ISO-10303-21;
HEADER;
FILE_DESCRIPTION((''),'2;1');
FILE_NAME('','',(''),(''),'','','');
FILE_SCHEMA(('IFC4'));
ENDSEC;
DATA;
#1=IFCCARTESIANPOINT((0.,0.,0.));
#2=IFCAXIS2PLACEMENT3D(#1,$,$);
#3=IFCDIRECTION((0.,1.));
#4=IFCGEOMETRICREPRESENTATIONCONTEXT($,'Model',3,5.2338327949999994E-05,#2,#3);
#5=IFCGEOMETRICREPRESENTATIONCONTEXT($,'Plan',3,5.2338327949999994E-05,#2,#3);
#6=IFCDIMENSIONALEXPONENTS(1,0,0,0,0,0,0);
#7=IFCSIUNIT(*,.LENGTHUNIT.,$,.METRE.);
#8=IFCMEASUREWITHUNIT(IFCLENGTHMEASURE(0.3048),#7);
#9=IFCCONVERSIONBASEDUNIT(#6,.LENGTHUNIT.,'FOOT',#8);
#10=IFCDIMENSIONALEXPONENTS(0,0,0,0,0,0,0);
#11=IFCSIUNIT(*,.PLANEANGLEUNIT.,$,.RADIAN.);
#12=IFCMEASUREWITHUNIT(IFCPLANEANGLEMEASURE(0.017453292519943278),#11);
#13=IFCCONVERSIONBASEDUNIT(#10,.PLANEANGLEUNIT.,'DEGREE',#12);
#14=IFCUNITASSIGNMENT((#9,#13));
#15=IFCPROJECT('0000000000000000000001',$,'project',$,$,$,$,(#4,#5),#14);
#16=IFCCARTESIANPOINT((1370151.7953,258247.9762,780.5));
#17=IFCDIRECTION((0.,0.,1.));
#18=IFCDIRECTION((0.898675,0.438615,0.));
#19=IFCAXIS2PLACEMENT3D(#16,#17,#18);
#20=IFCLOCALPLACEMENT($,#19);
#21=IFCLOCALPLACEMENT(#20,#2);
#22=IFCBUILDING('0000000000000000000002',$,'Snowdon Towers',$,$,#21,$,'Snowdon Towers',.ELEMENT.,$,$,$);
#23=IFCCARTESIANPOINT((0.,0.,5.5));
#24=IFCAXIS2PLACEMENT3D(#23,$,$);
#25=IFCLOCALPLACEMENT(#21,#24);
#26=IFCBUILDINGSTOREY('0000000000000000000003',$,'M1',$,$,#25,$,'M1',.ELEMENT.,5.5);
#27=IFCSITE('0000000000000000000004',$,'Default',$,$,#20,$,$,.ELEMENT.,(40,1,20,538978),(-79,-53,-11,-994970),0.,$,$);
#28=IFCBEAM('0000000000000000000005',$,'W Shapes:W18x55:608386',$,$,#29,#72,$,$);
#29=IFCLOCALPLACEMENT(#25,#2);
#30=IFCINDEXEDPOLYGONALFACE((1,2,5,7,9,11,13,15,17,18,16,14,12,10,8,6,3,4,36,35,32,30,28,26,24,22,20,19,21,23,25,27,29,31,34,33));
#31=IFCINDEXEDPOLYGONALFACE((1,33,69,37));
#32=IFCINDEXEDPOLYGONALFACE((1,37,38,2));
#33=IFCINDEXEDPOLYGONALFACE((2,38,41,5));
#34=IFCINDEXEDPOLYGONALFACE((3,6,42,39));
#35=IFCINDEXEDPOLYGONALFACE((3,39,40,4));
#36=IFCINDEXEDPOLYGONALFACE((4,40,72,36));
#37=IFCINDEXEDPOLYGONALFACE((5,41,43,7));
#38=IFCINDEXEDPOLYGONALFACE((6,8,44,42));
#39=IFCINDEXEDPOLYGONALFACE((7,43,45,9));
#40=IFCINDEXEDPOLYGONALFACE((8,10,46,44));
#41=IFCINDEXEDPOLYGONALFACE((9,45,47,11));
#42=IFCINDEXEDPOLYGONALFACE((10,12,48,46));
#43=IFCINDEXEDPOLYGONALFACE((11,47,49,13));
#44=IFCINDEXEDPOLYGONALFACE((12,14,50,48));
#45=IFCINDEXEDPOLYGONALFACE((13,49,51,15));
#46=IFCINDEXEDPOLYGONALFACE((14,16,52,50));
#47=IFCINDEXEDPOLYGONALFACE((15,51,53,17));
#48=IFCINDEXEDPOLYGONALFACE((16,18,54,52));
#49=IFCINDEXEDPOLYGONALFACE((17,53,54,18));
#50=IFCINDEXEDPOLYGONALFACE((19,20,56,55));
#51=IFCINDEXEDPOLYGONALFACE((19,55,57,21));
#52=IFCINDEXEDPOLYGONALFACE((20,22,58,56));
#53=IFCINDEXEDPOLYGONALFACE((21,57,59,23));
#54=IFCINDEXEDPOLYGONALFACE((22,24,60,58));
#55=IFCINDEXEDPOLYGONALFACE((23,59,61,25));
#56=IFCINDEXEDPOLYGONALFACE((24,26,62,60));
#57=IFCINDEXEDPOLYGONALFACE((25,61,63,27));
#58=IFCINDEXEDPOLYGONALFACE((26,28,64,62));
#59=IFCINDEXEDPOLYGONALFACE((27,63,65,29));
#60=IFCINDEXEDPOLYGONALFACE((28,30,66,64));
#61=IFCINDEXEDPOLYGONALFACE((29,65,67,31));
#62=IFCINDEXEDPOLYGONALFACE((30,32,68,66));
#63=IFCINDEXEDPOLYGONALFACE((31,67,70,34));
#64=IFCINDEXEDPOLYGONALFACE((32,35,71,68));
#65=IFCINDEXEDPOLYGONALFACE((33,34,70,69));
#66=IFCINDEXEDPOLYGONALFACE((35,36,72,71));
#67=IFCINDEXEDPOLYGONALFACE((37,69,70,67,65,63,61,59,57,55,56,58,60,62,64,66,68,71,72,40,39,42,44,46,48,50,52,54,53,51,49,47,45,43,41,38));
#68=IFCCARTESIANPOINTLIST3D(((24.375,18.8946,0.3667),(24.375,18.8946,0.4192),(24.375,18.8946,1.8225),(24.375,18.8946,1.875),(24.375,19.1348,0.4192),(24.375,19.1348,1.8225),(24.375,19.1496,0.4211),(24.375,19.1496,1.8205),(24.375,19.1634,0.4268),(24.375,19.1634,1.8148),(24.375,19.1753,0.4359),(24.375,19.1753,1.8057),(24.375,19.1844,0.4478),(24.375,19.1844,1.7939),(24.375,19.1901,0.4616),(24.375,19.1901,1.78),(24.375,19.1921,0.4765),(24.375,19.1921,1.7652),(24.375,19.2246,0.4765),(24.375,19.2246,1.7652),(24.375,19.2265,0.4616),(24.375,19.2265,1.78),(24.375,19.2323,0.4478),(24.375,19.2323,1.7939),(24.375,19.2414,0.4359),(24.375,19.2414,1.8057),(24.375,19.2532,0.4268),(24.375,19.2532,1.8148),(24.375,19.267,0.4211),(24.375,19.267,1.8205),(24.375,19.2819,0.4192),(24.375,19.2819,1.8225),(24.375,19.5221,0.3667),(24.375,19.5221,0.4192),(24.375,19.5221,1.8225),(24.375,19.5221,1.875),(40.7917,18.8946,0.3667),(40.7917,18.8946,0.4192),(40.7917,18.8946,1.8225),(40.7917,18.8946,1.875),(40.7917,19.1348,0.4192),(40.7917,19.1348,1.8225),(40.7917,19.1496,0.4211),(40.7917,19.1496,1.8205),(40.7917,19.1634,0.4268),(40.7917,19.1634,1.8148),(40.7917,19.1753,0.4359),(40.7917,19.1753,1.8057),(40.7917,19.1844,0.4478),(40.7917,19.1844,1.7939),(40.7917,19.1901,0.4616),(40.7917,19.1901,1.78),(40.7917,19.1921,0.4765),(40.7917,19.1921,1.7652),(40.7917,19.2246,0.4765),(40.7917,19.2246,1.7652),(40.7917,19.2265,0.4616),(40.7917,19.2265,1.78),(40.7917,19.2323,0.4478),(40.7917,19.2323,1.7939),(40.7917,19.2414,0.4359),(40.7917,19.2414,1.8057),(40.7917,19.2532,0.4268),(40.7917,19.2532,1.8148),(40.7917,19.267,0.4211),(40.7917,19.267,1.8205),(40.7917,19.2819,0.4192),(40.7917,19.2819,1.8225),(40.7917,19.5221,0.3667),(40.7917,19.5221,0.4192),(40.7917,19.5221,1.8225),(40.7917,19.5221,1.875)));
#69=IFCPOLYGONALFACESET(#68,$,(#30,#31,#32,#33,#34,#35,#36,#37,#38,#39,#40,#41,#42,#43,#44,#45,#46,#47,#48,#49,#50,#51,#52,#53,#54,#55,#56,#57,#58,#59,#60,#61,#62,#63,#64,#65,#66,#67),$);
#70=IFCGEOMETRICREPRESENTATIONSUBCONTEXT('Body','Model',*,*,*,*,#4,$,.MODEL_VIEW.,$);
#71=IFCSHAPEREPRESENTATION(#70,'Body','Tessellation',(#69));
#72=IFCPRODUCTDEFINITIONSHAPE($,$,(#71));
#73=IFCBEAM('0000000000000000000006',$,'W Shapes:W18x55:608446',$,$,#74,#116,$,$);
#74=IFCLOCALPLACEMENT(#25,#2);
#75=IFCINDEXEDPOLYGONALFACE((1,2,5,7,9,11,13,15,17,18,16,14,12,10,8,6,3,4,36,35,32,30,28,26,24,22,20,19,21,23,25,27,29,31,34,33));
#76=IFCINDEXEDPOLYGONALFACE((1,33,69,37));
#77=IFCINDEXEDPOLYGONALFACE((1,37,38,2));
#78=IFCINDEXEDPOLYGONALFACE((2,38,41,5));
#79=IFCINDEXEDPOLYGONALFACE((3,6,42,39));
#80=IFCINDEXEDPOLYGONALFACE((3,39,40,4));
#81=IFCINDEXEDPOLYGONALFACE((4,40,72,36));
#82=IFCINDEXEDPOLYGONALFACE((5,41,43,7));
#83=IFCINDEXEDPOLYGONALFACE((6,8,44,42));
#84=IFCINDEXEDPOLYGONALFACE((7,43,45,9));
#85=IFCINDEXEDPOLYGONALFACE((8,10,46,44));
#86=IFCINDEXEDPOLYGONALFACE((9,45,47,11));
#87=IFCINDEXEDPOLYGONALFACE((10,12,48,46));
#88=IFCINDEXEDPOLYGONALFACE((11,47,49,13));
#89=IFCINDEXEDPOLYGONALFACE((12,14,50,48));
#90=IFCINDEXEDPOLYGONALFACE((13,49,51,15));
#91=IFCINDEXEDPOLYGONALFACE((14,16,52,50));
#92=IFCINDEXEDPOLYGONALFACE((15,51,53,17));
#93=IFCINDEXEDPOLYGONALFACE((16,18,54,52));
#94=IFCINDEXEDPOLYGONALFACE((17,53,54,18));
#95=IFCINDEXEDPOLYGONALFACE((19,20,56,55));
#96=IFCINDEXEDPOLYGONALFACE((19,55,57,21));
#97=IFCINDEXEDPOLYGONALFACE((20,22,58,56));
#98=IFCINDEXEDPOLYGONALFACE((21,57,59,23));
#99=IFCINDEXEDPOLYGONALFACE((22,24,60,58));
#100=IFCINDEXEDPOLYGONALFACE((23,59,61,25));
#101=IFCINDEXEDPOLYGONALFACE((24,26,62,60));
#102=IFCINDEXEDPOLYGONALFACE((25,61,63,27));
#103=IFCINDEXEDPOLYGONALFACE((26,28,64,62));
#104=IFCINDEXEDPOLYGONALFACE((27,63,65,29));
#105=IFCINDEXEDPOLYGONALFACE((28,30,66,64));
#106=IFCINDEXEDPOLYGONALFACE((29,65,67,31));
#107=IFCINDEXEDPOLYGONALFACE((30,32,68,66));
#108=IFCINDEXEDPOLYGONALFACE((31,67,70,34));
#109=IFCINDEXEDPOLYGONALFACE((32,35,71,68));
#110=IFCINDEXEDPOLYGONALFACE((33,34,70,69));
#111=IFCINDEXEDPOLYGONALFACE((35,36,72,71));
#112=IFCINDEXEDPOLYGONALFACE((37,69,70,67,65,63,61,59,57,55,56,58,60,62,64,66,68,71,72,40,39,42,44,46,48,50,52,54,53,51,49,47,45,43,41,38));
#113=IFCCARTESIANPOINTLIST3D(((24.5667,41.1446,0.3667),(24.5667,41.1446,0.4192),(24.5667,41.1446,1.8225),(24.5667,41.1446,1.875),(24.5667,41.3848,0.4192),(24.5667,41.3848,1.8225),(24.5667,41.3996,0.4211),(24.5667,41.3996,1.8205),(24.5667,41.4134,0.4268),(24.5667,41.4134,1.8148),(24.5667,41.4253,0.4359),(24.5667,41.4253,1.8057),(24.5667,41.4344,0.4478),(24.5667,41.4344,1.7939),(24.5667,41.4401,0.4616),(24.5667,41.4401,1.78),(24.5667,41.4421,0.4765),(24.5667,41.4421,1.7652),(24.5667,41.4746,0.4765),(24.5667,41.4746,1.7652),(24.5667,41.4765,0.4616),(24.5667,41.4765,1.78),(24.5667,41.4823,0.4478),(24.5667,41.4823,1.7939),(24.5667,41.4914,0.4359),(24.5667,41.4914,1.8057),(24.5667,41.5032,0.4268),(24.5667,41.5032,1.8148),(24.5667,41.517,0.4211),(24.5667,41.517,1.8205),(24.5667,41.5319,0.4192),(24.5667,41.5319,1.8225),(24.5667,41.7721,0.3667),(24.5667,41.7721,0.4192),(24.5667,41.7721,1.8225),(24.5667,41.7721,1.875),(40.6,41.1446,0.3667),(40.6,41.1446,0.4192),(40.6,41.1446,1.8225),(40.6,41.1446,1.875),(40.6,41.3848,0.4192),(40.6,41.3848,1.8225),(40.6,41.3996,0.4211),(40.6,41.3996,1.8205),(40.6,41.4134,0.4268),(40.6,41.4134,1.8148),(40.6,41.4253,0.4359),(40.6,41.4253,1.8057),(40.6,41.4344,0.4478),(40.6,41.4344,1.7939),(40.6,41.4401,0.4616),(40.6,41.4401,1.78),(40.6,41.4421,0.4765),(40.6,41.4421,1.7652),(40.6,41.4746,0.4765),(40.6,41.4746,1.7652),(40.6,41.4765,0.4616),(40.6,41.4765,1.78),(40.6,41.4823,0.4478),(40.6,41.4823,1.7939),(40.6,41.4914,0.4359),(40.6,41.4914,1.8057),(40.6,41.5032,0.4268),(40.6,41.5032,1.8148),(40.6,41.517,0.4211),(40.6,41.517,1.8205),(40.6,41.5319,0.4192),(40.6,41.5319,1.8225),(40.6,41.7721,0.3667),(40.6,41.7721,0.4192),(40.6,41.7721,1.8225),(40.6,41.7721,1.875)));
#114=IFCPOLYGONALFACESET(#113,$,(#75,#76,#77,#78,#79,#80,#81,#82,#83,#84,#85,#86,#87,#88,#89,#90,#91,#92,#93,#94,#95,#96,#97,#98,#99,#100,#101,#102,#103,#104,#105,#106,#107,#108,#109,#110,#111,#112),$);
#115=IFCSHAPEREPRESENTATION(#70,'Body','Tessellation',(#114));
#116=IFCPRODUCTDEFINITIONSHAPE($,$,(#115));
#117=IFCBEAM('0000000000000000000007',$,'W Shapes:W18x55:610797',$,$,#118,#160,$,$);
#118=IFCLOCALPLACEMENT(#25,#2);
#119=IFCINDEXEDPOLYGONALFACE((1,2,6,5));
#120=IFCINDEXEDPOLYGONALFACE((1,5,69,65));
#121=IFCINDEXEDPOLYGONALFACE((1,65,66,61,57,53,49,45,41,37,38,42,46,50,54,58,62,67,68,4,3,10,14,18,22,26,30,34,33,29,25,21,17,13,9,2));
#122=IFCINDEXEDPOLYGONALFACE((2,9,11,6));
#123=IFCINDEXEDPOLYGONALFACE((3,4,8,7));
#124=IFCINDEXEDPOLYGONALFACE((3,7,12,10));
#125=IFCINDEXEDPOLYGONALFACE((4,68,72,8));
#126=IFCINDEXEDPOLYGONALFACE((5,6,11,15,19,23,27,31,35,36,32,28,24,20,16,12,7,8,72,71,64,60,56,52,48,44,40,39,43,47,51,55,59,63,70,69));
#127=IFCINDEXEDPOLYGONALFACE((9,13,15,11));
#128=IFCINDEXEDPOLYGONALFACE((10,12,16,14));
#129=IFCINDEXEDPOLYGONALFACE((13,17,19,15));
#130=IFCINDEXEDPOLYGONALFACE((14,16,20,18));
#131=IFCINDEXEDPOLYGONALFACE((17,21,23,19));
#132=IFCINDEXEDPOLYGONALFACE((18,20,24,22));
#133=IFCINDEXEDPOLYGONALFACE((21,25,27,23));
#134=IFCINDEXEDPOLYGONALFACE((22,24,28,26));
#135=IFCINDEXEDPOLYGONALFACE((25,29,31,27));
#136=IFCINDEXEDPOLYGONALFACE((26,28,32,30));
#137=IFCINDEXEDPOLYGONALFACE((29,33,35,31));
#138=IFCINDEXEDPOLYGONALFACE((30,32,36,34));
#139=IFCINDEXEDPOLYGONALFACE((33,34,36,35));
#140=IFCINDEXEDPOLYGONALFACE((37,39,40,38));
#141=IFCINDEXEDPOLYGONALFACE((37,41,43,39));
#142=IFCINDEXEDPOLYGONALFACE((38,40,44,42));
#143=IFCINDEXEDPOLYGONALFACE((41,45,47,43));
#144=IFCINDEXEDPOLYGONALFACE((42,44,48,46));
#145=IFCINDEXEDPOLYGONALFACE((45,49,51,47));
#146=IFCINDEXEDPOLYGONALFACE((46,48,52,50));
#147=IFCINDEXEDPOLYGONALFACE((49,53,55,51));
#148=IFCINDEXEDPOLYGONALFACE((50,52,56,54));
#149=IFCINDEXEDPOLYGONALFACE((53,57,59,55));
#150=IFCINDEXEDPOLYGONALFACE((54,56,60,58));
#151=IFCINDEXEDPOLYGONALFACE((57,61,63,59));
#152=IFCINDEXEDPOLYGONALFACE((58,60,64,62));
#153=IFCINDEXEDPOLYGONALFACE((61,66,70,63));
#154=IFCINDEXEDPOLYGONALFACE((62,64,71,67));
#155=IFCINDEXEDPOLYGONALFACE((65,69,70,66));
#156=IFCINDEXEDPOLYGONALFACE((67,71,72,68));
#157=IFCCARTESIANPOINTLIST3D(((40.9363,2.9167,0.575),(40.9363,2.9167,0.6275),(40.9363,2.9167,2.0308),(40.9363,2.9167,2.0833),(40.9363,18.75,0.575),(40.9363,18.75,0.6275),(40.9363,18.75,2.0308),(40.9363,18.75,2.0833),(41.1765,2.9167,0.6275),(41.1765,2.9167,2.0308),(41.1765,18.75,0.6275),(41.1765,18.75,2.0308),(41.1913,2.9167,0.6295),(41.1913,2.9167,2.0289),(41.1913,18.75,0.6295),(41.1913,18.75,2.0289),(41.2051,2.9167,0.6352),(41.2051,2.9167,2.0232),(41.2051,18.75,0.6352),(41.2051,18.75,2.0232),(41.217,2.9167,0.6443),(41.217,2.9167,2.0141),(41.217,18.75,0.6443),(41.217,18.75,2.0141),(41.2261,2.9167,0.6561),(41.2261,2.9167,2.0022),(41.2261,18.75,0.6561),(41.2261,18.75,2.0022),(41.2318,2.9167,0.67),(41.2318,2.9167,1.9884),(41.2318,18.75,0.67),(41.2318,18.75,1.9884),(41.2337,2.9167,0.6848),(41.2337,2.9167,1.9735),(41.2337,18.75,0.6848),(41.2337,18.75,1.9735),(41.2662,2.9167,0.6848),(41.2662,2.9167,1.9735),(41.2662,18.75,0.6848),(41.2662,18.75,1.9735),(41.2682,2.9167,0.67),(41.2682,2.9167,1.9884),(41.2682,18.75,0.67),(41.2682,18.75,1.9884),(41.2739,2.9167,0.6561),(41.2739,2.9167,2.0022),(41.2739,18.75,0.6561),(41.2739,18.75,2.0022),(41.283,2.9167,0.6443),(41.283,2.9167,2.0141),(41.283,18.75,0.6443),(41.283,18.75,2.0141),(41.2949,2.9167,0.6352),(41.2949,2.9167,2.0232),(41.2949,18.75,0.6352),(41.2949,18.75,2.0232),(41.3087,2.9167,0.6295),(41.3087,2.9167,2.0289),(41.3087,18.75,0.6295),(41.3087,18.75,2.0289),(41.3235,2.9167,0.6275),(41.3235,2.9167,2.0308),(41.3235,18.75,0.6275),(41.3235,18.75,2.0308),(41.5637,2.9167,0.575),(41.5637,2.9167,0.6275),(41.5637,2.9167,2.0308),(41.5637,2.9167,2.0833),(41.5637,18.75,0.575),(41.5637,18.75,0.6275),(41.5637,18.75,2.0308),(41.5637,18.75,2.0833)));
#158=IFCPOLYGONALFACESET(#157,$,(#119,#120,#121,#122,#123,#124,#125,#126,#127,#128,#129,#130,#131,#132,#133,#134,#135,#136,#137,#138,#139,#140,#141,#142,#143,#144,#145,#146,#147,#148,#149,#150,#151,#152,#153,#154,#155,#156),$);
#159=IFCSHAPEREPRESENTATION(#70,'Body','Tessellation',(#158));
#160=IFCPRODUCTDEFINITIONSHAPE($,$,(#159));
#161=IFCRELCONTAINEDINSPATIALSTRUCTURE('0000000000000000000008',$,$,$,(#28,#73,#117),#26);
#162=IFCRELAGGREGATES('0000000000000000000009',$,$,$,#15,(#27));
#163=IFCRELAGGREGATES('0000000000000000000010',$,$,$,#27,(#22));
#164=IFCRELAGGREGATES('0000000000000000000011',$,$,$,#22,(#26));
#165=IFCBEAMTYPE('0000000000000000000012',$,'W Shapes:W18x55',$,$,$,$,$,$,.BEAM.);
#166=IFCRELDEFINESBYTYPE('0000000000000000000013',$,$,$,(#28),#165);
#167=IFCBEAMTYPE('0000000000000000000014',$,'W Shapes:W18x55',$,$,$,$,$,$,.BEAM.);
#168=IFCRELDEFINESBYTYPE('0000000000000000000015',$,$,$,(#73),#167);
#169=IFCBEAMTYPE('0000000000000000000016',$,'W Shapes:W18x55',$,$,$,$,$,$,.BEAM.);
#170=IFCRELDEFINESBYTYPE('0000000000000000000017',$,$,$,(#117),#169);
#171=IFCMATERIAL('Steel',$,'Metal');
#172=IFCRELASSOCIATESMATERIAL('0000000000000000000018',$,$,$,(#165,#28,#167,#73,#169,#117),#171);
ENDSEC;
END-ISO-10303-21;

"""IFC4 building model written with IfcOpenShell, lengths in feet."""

from ifc_helpers import new_model, entity, si_unit, converted_unit, direction, frame, origin, place, context, subcontext, project, spatial, line, arc, indexed_curve, outline, extrude, source, transform, mapped, material, type_object, type_shapes, element, save


model = new_model("IFC4")

# Units and contexts
model_context = context("Model", 3, precision=5.2338327949999994e-05, world=origin(), true_north=direction((0.0, 1.0)))
plan_context = context("Plan", 3, precision=5.2338327949999994e-05, world=origin(), true_north=direction((0.0, 1.0)))
body_context = subcontext(model_context, "Body", "Model", "MODEL_VIEW")
ifc_project = project(units=[converted_unit("LENGTHUNIT", "FOOT", entity("IfcLengthMeasure", 0.3048), si_unit("LENGTHUNIT", "METRE"), dimensions=[1, 0, 0, 0, 0, 0, 0]), converted_unit("PLANEANGLEUNIT", "DEGREE", entity("IfcPlaneAngleMeasure", 0.017453292519943278), si_unit("PLANEANGLEUNIT", "RADIAN"), dimensions=[0, 0, 0, 0, 0, 0, 0])], contexts=[model_context, plan_context])

# Site, building, storey
site_placement = place(None, frame((1370151.7953, 258247.9762, 780.5), z_axis=(0.0, 0.0, 1.0), x_axis=(0.898675, 0.438615, 0.0)))
site = spatial("IfcSite", under=ifc_project, at=site_placement, Name="Default", CompositionType="ELEMENT", RefLatitude=(40, 1, 20, 538978), RefLongitude=(-79, -53, -11, -994970), RefElevation=0.0)
building_placement = place(site_placement, origin())
building = spatial("IfcBuilding", under=site, at=building_placement, Name="Snowdon Towers", LongName="Snowdon Towers", CompositionType="ELEMENT")
storey_placement = place(building_placement, frame((0.0, 0.0, 5.5)))
storey = spatial("IfcBuildingStorey", under=building, at=storey_placement, Name="M1", LongName="M1", CompositionType="ELEMENT", Elevation=5.5)

# Beams
ifc_material_1 = material(Name="Steel", Category="Metal")
beam_type_1 = type_object("IfcBeamType", Name="W Shapes:W18x55", PredefinedType="BEAM", material=ifc_material_1)
shared_shape_1 = source(origin(), body_context, "Body", "SweptSolid", [
    extrude(outline(indexed_curve([(-0.7542, -0.3138), (-0.7017, -0.3138), (-0.7017, -0.0735), (-0.6849, -0.033), (-0.6444, -0.0162), (0.6444, -0.0162), (0.6849, -0.033), (0.7017, -0.0735), (0.7017, -0.3138), (0.7542, -0.3138), (0.7542, 0.3138), (0.7017, 0.3138), (0.7017, 0.0735), (0.6849, 0.033), (0.6444, 0.0163), (-0.6444, 0.0163), (-0.6849, 0.033), (-0.7017, 0.0735), (-0.7017, 0.3137), (-0.7542, 0.3137)], segments=[line(1, 2, 3), arc(3, 4, 5), line(5, 6), arc(6, 7, 8), line(8, 9, 10, 11, 12, 13), arc(13, 14, 15), line(15, 16), arc(16, 17, 18), line(18, 19, 20, 1)], self_intersect=False)), frame((-8.2083, 0.0, 0.0), z_axis=(1.0, 0.0, 0.0), x_axis=(0.0, 0.0, -1.0)), (0.0, 0.0, 1.0), 16.4167),
])
type_shapes(beam_type_1, [shared_shape_1])
beam_1_placement = place(storey_placement, frame((32.5833, 19.2083, 1.1208)))
element("IfcBeam", 1, at=beam_1_placement, inside=storey, type_object=beam_type_1, material=ifc_material_1, Name="W Shapes:W18x55:608386", context=body_context, shape_type="MappedRepresentation", body=[
    mapped(shared_shape_1, transform((0.0, 0.0, 0.0), scale=1.0)),
])
beam_type_2 = type_object("IfcBeamType", Name="W Shapes:W18x55", PredefinedType="BEAM", material=ifc_material_1)
shared_shape_2 = source(origin(), body_context, "Body", "SweptSolid", [
    extrude(outline(indexed_curve([(-0.7542, -0.3138), (-0.7017, -0.3138), (-0.7017, -0.0735), (-0.6849, -0.033), (-0.6444, -0.0162), (0.6444, -0.0162), (0.6849, -0.033), (0.7017, -0.0735), (0.7017, -0.3138), (0.7542, -0.3138), (0.7542, 0.3138), (0.7017, 0.3138), (0.7017, 0.0735), (0.6849, 0.033), (0.6444, 0.0163), (-0.6444, 0.0163), (-0.6849, 0.033), (-0.7017, 0.0735), (-0.7017, 0.3137), (-0.7542, 0.3137)], segments=[line(1, 2, 3), arc(3, 4, 5), line(5, 6), arc(6, 7, 8), line(8, 9, 10, 11, 12, 13), arc(13, 14, 15), line(15, 16), arc(16, 17, 18), line(18, 19, 20, 1)], self_intersect=False)), frame((-8.0167, 0.0, 0.0), z_axis=(1.0, 0.0, 0.0), x_axis=(0.0, 0.0, -1.0)), (0.0, 0.0, 1.0), 16.0333),
])
type_shapes(beam_type_2, [shared_shape_2])
beam_2_placement = place(storey_placement, frame((32.5833, 41.4583, 1.1208)))
element("IfcBeam", 2, at=beam_2_placement, inside=storey, type_object=beam_type_2, material=ifc_material_1, Name="W Shapes:W18x55:608446", context=body_context, shape_type="MappedRepresentation", body=[
    mapped(shared_shape_2, transform((0.0, 0.0, 0.0), scale=1.0)),
])
beam_type_3 = type_object("IfcBeamType", Name="W Shapes:W18x55", PredefinedType="BEAM", material=ifc_material_1)
shared_shape_3 = source(origin(), body_context, "Body", "SweptSolid", [
    extrude(outline(indexed_curve([(-0.7542, -0.3138), (-0.7017, -0.3138), (-0.7017, -0.0735), (-0.6849, -0.033), (-0.6444, -0.0162), (0.6444, -0.0162), (0.6849, -0.033), (0.7017, -0.0735), (0.7017, -0.3138), (0.7542, -0.3138), (0.7542, 0.3138), (0.7017, 0.3138), (0.7017, 0.0735), (0.6849, 0.033), (0.6444, 0.0163), (-0.6444, 0.0163), (-0.6849, 0.033), (-0.7017, 0.0735), (-0.7017, 0.3137), (-0.7542, 0.3137)], segments=[line(1, 2, 3), arc(3, 4, 5), line(5, 6), arc(6, 7, 8), line(8, 9, 10, 11, 12, 13), arc(13, 14, 15), line(15, 16), arc(16, 17, 18), line(18, 19, 20, 1)], self_intersect=False)), frame((-7.875, 0.0, 0.0), z_axis=(1.0, 0.0, 0.0), x_axis=(0.0, 0.0, -1.0)), (0.0, 0.0, 1.0), 15.8333),
])
type_shapes(beam_type_3, [shared_shape_3])
beam_3_placement = place(storey_placement, frame((41.25, 10.7917, 1.3292), z_axis=(0.0, 0.0, 1.0), x_axis=(0.0, 1.0, 0.0)))
element("IfcBeam", 3, at=beam_3_placement, inside=storey, type_object=beam_type_3, material=ifc_material_1, Name="W Shapes:W18x55:610797", context=body_context, shape_type="MappedRepresentation", body=[
    mapped(shared_shape_3, transform((0.0, 0.0, 0.0), scale=1.0)),
])

save(model, "model.ifc")
